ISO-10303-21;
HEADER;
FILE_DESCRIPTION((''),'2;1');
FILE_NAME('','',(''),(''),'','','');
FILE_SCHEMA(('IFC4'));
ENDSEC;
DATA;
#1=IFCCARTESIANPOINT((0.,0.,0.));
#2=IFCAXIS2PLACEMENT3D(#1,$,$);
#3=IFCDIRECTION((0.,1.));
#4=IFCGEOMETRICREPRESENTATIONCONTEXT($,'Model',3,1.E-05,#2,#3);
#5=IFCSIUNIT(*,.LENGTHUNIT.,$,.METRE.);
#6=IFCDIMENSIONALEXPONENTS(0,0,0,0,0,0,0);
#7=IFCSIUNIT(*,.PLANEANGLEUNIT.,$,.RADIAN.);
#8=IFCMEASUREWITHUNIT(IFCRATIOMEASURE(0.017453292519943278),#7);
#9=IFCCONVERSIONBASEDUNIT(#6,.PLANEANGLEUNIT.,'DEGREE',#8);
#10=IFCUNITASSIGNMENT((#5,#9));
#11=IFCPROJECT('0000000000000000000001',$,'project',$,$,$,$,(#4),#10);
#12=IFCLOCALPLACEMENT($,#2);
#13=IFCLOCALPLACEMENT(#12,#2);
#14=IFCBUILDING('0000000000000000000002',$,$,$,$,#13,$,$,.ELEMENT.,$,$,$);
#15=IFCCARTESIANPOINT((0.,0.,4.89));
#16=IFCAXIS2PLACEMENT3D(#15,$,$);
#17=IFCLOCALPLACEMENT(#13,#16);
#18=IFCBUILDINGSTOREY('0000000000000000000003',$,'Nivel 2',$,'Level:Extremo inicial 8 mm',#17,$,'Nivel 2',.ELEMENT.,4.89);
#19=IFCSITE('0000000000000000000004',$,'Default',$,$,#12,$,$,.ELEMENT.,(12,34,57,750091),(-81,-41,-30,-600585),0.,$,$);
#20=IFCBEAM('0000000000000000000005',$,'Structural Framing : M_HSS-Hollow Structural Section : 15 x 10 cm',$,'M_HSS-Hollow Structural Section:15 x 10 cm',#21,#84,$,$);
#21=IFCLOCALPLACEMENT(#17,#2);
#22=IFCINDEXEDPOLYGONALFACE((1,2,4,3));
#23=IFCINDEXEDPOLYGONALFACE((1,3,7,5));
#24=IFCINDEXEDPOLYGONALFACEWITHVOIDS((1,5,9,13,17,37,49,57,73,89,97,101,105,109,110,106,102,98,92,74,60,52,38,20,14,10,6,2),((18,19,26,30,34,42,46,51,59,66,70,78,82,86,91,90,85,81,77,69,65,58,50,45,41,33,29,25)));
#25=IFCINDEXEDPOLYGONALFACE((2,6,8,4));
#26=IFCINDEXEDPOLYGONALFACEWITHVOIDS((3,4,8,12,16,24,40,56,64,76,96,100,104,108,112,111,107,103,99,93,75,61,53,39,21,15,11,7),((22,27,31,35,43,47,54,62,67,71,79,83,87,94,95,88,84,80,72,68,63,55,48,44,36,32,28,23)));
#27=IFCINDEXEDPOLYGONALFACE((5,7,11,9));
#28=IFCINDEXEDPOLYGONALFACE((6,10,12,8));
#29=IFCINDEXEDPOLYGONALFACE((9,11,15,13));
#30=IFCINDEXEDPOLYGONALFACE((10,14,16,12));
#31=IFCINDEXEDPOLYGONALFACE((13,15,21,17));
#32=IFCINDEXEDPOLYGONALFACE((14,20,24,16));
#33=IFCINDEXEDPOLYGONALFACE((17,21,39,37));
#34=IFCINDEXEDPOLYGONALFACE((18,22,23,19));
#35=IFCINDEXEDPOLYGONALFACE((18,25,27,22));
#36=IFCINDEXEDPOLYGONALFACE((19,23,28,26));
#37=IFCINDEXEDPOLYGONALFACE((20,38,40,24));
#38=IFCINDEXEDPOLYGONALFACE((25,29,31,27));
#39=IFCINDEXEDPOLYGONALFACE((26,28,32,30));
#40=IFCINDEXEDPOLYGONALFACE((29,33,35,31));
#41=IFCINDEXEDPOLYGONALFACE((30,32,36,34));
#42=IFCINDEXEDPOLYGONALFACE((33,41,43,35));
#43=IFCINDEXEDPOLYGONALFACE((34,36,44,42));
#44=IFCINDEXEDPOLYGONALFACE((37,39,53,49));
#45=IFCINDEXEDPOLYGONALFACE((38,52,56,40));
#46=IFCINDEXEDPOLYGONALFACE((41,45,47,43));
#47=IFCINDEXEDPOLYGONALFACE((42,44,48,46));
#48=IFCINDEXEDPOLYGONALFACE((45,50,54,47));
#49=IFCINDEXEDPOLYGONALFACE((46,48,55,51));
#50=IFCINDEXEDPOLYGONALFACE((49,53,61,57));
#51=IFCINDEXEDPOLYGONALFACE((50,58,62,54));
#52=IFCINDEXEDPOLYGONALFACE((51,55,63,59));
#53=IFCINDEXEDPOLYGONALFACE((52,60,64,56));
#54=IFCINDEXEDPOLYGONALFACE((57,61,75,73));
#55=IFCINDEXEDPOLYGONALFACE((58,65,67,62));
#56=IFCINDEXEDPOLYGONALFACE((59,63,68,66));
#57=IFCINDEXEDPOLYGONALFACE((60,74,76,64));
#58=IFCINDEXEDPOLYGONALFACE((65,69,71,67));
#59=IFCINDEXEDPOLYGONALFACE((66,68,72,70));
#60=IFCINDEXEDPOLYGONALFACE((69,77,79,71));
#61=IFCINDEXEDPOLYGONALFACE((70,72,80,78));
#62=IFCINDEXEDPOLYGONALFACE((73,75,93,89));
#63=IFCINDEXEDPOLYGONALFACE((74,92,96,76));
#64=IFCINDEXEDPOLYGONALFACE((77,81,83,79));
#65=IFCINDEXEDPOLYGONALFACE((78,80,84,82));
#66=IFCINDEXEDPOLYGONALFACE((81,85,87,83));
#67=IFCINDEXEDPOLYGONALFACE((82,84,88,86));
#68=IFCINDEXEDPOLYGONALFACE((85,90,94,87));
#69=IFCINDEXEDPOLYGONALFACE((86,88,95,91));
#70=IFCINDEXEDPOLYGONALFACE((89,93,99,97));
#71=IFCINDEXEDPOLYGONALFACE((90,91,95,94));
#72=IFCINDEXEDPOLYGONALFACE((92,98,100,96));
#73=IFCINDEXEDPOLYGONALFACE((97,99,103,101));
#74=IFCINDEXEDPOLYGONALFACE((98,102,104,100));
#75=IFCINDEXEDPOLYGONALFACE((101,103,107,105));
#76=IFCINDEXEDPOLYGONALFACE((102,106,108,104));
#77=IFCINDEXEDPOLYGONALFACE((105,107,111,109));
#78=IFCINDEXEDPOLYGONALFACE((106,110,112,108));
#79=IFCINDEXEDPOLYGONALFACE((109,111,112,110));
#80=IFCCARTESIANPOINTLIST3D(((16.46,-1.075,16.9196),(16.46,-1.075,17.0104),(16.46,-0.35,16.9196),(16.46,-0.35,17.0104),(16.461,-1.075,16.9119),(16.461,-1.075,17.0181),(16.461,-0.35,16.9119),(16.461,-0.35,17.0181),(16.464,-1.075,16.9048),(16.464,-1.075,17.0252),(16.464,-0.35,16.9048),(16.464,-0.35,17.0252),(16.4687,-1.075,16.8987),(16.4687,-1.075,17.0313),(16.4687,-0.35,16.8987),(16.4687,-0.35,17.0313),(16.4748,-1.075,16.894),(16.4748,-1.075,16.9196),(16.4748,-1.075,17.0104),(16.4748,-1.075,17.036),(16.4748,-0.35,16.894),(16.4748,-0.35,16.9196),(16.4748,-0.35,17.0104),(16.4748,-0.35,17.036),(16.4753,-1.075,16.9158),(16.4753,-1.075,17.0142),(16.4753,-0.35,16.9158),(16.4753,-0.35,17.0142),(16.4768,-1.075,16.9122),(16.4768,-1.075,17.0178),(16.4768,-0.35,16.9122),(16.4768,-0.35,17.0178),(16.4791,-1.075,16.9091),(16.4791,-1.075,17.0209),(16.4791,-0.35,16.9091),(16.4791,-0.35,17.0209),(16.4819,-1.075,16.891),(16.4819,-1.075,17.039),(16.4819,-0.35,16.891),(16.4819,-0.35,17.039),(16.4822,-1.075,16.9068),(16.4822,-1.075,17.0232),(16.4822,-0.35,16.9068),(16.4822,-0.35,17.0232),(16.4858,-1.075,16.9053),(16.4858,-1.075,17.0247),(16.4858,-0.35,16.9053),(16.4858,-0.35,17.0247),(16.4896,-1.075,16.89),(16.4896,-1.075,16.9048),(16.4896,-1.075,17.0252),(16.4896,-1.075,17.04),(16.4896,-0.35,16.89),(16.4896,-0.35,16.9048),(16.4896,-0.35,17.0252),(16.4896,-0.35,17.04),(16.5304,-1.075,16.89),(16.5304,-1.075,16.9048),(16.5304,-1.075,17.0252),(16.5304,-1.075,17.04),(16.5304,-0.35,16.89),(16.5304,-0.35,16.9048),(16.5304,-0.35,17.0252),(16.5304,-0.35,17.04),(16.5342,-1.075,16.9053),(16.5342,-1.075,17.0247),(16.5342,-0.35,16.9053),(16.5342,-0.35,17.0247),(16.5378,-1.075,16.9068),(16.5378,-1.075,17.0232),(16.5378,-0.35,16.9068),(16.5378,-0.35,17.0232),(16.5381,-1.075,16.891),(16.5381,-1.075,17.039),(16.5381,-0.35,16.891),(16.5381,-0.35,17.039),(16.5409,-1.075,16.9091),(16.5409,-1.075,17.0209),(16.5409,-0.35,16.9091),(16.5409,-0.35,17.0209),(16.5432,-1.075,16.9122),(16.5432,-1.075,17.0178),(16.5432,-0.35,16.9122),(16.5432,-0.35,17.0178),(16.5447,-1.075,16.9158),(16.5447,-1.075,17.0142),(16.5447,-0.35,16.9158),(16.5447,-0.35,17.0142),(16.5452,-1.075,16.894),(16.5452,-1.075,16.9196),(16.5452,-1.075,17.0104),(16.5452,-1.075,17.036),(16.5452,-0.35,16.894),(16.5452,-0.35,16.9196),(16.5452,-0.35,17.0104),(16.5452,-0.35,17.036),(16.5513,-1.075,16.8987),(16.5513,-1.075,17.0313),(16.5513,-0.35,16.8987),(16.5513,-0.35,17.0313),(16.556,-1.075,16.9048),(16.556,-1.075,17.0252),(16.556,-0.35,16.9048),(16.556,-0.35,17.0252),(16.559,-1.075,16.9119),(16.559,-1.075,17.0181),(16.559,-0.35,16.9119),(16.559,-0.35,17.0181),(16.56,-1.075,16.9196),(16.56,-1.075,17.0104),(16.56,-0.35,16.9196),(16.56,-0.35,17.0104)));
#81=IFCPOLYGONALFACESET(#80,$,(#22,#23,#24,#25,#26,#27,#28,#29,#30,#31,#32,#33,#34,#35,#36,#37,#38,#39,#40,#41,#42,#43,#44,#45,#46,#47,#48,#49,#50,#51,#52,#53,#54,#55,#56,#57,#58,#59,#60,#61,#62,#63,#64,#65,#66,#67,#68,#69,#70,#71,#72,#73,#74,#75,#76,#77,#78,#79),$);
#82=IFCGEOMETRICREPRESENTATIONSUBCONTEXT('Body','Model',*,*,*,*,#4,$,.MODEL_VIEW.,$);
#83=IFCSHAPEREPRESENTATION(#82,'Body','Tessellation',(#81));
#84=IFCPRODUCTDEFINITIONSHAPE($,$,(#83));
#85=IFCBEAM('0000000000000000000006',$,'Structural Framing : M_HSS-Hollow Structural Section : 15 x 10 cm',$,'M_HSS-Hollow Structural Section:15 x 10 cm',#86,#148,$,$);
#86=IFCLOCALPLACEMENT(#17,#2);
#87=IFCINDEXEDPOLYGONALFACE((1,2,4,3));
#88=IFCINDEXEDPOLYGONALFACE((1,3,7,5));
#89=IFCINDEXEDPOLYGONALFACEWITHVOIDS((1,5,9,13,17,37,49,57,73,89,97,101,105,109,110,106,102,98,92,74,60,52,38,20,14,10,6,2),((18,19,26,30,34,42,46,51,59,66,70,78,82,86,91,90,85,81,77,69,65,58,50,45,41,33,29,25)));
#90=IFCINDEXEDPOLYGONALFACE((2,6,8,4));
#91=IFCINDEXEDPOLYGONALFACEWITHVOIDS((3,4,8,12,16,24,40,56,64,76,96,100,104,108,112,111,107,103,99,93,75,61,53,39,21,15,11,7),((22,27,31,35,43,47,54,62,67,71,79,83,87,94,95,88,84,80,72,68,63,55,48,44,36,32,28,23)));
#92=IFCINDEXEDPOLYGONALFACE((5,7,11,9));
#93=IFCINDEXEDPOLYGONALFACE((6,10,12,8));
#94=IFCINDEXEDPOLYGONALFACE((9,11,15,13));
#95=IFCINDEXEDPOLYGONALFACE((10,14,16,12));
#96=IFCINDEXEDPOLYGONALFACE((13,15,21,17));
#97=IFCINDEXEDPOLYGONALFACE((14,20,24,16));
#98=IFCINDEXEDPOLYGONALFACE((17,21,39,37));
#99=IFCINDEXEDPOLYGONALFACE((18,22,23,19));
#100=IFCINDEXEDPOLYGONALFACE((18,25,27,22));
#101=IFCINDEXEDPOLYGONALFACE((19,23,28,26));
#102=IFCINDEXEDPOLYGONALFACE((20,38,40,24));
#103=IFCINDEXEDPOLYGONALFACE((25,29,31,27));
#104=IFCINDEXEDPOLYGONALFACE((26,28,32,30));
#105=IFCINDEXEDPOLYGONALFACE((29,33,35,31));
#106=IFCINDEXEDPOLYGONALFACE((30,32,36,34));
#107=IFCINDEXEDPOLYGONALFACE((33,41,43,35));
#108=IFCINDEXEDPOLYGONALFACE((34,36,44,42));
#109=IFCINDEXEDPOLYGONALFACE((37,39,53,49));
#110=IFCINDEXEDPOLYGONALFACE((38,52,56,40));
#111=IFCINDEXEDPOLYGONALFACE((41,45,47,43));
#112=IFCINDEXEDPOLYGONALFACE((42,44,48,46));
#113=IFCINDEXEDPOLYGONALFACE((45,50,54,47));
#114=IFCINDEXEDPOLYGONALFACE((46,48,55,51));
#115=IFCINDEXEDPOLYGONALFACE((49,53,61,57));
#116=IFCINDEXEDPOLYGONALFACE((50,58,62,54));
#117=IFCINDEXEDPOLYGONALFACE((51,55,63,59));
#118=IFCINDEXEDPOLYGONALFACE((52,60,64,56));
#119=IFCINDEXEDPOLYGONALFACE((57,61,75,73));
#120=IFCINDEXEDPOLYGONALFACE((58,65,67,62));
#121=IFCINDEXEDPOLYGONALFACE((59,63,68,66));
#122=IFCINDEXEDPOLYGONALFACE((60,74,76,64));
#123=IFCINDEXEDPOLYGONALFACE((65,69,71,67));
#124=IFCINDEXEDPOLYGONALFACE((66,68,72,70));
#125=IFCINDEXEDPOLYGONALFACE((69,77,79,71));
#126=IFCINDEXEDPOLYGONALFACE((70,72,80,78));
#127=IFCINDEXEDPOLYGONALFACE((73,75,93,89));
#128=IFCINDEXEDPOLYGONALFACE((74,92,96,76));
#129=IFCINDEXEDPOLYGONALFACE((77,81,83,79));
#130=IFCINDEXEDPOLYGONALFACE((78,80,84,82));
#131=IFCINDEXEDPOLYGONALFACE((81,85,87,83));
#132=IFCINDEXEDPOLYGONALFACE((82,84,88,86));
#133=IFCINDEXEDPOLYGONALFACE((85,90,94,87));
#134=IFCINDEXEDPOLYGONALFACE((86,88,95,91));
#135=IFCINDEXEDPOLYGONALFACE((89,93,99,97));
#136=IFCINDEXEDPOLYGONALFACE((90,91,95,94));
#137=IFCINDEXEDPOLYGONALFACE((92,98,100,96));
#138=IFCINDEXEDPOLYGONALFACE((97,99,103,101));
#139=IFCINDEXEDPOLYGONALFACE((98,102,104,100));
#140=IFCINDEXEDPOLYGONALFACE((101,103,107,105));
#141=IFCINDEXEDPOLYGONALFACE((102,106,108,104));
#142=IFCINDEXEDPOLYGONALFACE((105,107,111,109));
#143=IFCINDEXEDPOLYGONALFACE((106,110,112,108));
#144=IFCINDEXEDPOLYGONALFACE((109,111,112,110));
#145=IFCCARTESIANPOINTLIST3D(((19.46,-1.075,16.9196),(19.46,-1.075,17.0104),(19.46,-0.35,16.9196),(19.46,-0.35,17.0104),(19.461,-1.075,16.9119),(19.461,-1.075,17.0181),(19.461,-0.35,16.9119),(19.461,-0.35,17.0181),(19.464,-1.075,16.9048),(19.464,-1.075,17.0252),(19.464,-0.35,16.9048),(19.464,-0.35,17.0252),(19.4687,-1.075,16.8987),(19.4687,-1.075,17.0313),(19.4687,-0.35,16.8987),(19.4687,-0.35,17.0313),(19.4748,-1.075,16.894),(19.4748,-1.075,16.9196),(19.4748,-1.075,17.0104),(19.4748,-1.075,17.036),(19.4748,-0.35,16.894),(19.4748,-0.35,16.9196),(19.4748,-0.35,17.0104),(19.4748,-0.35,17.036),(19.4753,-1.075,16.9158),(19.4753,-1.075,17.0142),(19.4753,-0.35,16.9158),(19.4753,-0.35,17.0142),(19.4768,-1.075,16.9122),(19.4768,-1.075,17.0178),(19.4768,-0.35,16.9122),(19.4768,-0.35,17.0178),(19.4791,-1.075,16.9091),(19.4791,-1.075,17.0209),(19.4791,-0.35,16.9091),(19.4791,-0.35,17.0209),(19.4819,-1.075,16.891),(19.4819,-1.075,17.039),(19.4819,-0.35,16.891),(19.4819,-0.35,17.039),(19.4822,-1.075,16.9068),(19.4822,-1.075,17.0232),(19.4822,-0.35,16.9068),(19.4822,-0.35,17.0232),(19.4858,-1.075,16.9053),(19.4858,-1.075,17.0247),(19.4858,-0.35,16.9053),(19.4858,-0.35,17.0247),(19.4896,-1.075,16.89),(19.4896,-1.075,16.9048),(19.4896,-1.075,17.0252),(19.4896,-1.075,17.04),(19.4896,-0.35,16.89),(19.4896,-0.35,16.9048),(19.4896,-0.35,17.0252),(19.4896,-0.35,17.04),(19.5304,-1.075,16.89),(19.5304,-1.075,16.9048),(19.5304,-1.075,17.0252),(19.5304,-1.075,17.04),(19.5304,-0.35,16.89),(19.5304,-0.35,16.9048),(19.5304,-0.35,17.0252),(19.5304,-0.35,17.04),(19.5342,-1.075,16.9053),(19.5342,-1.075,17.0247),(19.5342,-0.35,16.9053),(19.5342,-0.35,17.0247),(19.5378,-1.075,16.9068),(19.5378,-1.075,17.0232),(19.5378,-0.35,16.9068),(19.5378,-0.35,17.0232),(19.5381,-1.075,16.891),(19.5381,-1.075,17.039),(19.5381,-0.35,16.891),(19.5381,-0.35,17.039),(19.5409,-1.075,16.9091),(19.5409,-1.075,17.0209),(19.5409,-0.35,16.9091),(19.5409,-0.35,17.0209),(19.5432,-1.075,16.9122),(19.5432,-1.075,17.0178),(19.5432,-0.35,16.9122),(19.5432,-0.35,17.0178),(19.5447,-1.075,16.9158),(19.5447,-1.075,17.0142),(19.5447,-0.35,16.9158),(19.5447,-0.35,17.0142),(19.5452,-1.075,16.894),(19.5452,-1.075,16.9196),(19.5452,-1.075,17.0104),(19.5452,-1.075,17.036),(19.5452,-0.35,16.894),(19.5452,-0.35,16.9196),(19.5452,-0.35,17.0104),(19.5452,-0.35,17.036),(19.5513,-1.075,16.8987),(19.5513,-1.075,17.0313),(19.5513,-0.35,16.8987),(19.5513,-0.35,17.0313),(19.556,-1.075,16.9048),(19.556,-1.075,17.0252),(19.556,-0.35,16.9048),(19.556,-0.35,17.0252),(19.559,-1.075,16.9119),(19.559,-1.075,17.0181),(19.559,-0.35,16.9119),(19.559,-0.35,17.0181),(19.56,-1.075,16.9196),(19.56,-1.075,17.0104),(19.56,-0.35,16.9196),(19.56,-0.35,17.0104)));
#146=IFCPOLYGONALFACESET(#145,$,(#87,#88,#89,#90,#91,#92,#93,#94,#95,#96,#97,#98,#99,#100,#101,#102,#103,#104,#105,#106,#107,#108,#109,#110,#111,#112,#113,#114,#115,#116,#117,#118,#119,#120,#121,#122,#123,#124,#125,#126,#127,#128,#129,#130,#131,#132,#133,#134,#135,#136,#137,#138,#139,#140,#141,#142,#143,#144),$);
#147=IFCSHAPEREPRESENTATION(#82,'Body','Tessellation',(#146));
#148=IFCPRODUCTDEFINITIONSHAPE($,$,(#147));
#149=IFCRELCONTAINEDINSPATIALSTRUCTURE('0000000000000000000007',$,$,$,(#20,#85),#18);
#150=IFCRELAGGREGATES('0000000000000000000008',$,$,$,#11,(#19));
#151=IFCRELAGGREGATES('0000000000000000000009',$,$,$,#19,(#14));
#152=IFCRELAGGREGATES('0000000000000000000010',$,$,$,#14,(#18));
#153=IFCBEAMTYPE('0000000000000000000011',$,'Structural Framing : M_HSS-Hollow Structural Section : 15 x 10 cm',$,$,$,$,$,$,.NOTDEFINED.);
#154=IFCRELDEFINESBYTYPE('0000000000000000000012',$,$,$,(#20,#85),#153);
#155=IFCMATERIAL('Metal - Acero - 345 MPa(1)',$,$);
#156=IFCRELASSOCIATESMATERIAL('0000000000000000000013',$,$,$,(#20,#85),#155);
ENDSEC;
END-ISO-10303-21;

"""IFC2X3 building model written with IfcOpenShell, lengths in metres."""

from ifc_helpers import new_model, entity, si_unit, converted_unit, direction, frame, frame_2d, origin, place, context, subcontext, project, spatial, polyline, circle_curve, parameter, trimmed, segment, composite_curve, outline, extrude, material, type_object, element, save


model = new_model("IFC2X3")

# Units and contexts
model_context = context("Model", 3, precision=1e-05, world=origin(), true_north=direction((0.0, 1.0)))
body_context = subcontext(model_context, "Body", "Model", "MODEL_VIEW")
ifc_project = project(units=[si_unit("LENGTHUNIT", "METRE"), converted_unit("PLANEANGLEUNIT", "DEGREE", entity("IfcRatioMeasure", 0.017453292519943278), si_unit("PLANEANGLEUNIT", "RADIAN"), dimensions=[0, 0, 0, 0, 0, 0, 0])], contexts=[model_context])

# Site, building, storey
site_placement = place(None, origin())
site = spatial("IfcSite", under=ifc_project, at=site_placement, Name="Default", CompositionType="ELEMENT", RefLatitude=(12, 34, 57, 750091), RefLongitude=(-81, -41, -30, -600585), RefElevation=0.0)
building_placement = place(site_placement, origin())
building = spatial("IfcBuilding", under=site, at=building_placement, CompositionType="ELEMENT")
storey_placement = place(building_placement, frame((0.0, 0.0, 4.89)))
storey = spatial("IfcBuildingStorey", under=building, at=storey_placement, Name="Nivel 2", ObjectType="Level:Extremo inicial 8 mm", LongName="Nivel 2", CompositionType="ELEMENT", Elevation=4.89)

# Beams
ifc_material_1 = material(Name="Metal - Acero - 345 MPa(1)")
beam_type_1 = type_object("IfcBeamType", Name="Structural Framing : M_HSS-Hollow Structural Section : 15 x 10 cm", PredefinedType="NOTDEFINED")
beam_1_placement = place(storey_placement, frame((16.51, -1.425, 17.04), z_axis=(0.0, 0.0, 1.0), x_axis=(0.0, 1.0, 0.0)))
element("IfcBeam", 1, at=beam_1_placement, inside=storey, type_object=beam_type_1, material=ifc_material_1, Name="Structural Framing : M_HSS-Hollow Structural Section : 15 x 10 cm", ObjectType="M_HSS-Hollow Structural Section:15 x 10 cm", context=body_context, shape_type="SweptSolid", body=[
    extrude(outline(composite_curve([segment(trimmed(circle_curve(frame_2d((-0.0204, -0.0454), x_axis=(1.0, 0.0)), 0.0296), [parameter(180.0)], [parameter(270.0)], True, "PARAMETER"), True, "CONTINUOUS"), segment(polyline([(-0.0204, -0.075), (0.0204, -0.075)]), True, "CONTINUOUS"), segment(trimmed(circle_curve(frame_2d((0.0204, -0.0454), x_axis=(1.0, 0.0)), 0.0296), [parameter(270.0)], [parameter(0.0)], True, "PARAMETER"), True, "CONTINUOUS"), segment(polyline([(0.05, -0.0454), (0.05, 0.0454)]), True, "CONTINUOUS"), segment(trimmed(circle_curve(frame_2d((0.0204, 0.0454), x_axis=(1.0, 0.0)), 0.0296), [parameter(360.0)], [parameter(90.0)], True, "PARAMETER"), True, "CONTINUOUS"), segment(polyline([(0.0204, 0.075), (-0.0204, 0.075)]), True, "CONTINUOUS"), segment(trimmed(circle_curve(frame_2d((-0.0204, 0.0454), x_axis=(1.0, 0.0)), 0.0296), [parameter(90.0)], [parameter(180.0)], True, "PARAMETER"), True, "CONTINUOUS"), segment(polyline([(-0.05, 0.0454), (-0.05, -0.0454)]), True, "CONTINUOUS")], self_intersect=False), holes=[composite_curve([segment(polyline([(0.0204, -0.0602), (-0.0204, -0.0602)]), True, "CONTINUOUS"), segment(trimmed(circle_curve(frame_2d((-0.0204, -0.0454), x_axis=(1.0, 0.0)), 0.0148), [parameter(180.0)], [parameter(270.0)], True, "PARAMETER"), False, "CONTINUOUS"), segment(polyline([(-0.0352, -0.0454), (-0.0352, 0.0454)]), True, "CONTINUOUS"), segment(trimmed(circle_curve(frame_2d((-0.0204, 0.0454), x_axis=(1.0, 0.0)), 0.0148), [parameter(90.0)], [parameter(180.0)], True, "PARAMETER"), False, "CONTINUOUS"), segment(polyline([(-0.0204, 0.0602), (0.0204, 0.0602)]), True, "CONTINUOUS"), segment(trimmed(circle_curve(frame_2d((0.0204, 0.0454), x_axis=(1.0, 0.0)), 0.0148), [parameter(0.0)], [parameter(90.0)], True, "PARAMETER"), False, "CONTINUOUS"), segment(polyline([(0.0352, 0.0454), (0.0352, -0.0454)]), True, "CONTINUOUS"), segment(trimmed(circle_curve(frame_2d((0.0204, -0.0454), x_axis=(1.0, 0.0)), 0.0148), [parameter(270.0)], [parameter(0.0)], True, "PARAMETER"), False, "CONTINUOUS")], self_intersect=False)]), frame((0.35, 0.0, -0.075), z_axis=(1.0, 0.0, 0.0), x_axis=(0.0, -1.0, 0.0)), (0.0, 0.0, 1.0), 0.725),
])
beam_2_placement = place(storey_placement, frame((19.51, -1.425, 17.04), z_axis=(0.0, 0.0, 1.0), x_axis=(0.0, 1.0, 0.0)))
element("IfcBeam", 2, at=beam_2_placement, inside=storey, type_object=beam_type_1, material=ifc_material_1, Name="Structural Framing : M_HSS-Hollow Structural Section : 15 x 10 cm", ObjectType="M_HSS-Hollow Structural Section:15 x 10 cm", context=body_context, shape_type="SweptSolid", body=[
    extrude(outline(composite_curve([segment(trimmed(circle_curve(frame_2d((-0.0204, -0.0454), x_axis=(1.0, 0.0)), 0.0296), [parameter(180.0)], [parameter(270.0)], True, "PARAMETER"), True, "CONTINUOUS"), segment(polyline([(-0.0204, -0.075), (0.0204, -0.075)]), True, "CONTINUOUS"), segment(trimmed(circle_curve(frame_2d((0.0204, -0.0454), x_axis=(1.0, 0.0)), 0.0296), [parameter(270.0)], [parameter(0.0)], True, "PARAMETER"), True, "CONTINUOUS"), segment(polyline([(0.05, -0.0454), (0.05, 0.0454)]), True, "CONTINUOUS"), segment(trimmed(circle_curve(frame_2d((0.0204, 0.0454), x_axis=(1.0, 0.0)), 0.0296), [parameter(360.0)], [parameter(90.0)], True, "PARAMETER"), True, "CONTINUOUS"), segment(polyline([(0.0204, 0.075), (-0.0204, 0.075)]), True, "CONTINUOUS"), segment(trimmed(circle_curve(frame_2d((-0.0204, 0.0454), x_axis=(1.0, 0.0)), 0.0296), [parameter(90.0)], [parameter(180.0)], True, "PARAMETER"), True, "CONTINUOUS"), segment(polyline([(-0.05, 0.0454), (-0.05, -0.0454)]), True, "CONTINUOUS")], self_intersect=False), holes=[composite_curve([segment(polyline([(0.0204, -0.0602), (-0.0204, -0.0602)]), True, "CONTINUOUS"), segment(trimmed(circle_curve(frame_2d((-0.0204, -0.0454), x_axis=(1.0, 0.0)), 0.0148), [parameter(180.0)], [parameter(270.0)], True, "PARAMETER"), False, "CONTINUOUS"), segment(polyline([(-0.0352, -0.0454), (-0.0352, 0.0454)]), True, "CONTINUOUS"), segment(trimmed(circle_curve(frame_2d((-0.0204, 0.0454), x_axis=(1.0, 0.0)), 0.0148), [parameter(90.0)], [parameter(180.0)], True, "PARAMETER"), False, "CONTINUOUS"), segment(polyline([(-0.0204, 0.0602), (0.0204, 0.0602)]), True, "CONTINUOUS"), segment(trimmed(circle_curve(frame_2d((0.0204, 0.0454), x_axis=(1.0, 0.0)), 0.0148), [parameter(0.0)], [parameter(90.0)], True, "PARAMETER"), False, "CONTINUOUS"), segment(polyline([(0.0352, 0.0454), (0.0352, -0.0454)]), True, "CONTINUOUS"), segment(trimmed(circle_curve(frame_2d((0.0204, -0.0454), x_axis=(1.0, 0.0)), 0.0148), [parameter(270.0)], [parameter(0.0)], True, "PARAMETER"), False, "CONTINUOUS")], self_intersect=False)]), frame((0.35, 0.0, -0.075), z_axis=(1.0, 0.0, 0.0), x_axis=(0.0, -1.0, 0.0)), (0.0, 0.0, 1.0), 0.725),
])

save(model, "model.ifc")
